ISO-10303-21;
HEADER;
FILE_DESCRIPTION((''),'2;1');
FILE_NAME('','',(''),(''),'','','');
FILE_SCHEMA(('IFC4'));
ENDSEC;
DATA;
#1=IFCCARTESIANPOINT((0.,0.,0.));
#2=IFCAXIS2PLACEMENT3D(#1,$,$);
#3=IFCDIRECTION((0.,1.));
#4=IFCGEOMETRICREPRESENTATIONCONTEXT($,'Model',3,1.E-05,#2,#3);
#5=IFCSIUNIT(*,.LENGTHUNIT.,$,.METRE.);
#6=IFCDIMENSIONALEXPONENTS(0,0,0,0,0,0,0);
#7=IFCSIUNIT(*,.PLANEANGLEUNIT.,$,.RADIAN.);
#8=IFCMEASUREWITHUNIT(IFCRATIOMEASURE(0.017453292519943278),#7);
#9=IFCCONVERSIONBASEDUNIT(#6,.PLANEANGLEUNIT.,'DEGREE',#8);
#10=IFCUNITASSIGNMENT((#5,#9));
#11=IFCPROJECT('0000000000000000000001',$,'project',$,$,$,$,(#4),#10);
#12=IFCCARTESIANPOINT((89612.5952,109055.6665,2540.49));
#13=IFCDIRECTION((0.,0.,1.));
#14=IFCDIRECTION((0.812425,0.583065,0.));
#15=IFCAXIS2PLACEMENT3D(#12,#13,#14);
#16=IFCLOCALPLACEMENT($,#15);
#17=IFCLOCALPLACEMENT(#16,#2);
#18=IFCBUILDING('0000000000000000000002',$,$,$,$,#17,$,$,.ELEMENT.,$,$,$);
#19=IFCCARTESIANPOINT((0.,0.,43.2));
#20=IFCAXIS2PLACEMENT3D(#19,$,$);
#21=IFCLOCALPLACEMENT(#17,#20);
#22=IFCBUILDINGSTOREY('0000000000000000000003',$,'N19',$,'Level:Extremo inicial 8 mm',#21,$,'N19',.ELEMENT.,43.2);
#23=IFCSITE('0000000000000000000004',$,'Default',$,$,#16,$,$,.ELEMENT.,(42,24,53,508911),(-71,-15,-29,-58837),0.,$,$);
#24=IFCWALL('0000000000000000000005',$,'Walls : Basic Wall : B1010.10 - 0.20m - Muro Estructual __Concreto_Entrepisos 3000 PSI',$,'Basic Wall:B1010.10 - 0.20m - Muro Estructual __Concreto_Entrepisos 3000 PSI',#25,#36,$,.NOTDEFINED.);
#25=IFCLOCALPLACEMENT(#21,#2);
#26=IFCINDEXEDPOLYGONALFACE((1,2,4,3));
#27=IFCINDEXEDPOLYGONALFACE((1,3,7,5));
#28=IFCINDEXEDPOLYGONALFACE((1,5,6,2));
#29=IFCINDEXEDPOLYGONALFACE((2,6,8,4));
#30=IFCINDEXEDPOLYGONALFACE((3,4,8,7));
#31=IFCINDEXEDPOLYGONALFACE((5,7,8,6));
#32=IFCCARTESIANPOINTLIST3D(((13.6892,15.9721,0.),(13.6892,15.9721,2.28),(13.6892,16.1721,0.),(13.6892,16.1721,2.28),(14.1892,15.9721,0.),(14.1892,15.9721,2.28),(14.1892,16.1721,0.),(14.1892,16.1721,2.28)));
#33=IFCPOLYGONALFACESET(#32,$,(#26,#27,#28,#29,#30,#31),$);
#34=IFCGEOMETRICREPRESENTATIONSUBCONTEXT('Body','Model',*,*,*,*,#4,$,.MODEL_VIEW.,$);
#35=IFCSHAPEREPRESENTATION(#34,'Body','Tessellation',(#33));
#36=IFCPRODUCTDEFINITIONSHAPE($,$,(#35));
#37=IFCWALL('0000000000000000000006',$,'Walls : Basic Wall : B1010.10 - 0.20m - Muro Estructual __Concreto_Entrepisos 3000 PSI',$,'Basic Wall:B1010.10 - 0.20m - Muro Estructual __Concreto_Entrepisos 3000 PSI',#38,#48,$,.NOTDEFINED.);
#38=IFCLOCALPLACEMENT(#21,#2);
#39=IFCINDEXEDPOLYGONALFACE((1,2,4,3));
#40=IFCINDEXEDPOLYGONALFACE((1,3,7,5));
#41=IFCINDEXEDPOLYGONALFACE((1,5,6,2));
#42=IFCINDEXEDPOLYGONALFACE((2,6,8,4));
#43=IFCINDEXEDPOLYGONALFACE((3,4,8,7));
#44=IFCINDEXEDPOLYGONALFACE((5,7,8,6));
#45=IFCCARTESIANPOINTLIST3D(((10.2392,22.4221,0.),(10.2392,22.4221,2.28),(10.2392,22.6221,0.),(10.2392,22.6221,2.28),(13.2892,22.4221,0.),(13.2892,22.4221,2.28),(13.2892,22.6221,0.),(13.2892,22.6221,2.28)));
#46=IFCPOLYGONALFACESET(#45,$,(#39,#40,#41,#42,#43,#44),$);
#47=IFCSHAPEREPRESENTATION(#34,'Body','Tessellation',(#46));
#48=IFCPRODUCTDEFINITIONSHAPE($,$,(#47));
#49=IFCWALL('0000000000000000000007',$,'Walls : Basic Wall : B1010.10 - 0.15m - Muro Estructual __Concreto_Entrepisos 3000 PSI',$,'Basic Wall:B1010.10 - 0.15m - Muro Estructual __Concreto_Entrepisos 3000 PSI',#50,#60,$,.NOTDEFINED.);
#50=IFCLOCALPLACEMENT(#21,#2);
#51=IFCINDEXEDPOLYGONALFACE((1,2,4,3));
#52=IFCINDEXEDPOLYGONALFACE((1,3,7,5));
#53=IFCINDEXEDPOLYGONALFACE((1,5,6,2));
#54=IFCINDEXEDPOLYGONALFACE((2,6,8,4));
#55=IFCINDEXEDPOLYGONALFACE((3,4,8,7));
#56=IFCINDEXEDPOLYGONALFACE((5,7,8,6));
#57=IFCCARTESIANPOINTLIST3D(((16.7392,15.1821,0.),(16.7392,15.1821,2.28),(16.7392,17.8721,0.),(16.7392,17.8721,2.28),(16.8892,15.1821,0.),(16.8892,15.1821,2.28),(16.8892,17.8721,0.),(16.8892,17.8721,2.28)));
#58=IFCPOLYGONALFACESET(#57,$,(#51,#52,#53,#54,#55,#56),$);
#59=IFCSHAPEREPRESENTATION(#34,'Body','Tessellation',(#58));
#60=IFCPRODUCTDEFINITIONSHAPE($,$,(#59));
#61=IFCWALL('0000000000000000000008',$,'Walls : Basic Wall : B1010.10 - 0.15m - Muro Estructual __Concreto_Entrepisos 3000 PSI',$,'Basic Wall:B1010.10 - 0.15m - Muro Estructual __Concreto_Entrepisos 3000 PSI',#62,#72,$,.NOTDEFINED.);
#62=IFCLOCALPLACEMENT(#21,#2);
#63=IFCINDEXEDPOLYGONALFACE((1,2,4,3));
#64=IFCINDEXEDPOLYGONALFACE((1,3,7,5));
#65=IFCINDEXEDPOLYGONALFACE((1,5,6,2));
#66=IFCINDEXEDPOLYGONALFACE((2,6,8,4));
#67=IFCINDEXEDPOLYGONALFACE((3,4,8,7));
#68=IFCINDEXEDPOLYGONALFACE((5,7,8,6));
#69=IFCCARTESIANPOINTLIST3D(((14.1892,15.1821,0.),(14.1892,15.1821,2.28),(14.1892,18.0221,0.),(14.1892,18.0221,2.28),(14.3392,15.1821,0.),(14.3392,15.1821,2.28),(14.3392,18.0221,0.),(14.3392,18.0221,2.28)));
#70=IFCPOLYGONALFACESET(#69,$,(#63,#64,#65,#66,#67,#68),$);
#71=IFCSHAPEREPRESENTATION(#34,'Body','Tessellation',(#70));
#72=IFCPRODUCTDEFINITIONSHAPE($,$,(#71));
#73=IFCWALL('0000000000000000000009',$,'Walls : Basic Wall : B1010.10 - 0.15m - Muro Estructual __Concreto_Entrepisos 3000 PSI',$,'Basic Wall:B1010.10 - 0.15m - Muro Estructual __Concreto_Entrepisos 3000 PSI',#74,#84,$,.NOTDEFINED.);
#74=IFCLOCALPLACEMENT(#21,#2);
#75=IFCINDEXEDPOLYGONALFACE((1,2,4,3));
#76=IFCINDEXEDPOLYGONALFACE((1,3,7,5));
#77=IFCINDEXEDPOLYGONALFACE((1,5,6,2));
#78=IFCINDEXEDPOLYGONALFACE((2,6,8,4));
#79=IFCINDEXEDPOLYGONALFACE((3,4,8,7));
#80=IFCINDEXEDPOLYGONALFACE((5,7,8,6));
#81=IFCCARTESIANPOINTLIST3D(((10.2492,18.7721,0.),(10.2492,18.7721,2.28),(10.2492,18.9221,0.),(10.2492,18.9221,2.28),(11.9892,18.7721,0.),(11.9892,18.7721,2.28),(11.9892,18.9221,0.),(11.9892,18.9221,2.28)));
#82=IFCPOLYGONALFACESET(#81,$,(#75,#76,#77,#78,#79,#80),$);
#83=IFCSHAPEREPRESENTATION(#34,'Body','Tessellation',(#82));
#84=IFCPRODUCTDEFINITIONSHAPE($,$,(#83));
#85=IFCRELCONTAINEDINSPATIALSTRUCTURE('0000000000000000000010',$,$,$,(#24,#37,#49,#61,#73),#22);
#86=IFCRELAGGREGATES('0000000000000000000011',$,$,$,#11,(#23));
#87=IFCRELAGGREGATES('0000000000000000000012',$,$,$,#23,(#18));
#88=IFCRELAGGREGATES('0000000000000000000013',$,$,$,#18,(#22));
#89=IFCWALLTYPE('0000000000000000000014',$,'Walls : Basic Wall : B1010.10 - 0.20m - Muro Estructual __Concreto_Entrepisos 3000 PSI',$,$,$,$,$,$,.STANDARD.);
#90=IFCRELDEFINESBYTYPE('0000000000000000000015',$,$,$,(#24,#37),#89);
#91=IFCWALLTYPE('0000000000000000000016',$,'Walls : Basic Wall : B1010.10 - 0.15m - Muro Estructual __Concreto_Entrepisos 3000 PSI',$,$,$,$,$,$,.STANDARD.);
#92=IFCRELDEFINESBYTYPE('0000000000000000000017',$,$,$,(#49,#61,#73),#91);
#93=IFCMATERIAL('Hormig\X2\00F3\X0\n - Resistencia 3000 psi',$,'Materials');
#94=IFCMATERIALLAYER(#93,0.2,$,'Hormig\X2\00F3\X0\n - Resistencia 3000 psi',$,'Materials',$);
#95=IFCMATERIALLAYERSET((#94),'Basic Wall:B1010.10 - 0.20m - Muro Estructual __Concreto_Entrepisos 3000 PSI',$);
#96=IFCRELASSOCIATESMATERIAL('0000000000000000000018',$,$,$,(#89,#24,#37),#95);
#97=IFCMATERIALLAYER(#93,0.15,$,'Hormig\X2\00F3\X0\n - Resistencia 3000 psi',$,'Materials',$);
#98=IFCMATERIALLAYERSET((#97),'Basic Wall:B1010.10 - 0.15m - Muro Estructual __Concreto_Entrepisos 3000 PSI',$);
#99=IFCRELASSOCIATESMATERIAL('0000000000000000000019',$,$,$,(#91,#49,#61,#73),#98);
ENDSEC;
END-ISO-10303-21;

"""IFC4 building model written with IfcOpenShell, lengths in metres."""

from ifc_helpers import new_model, entity, si_unit, converted_unit, direction, frame, frame_2d, origin, place, context, subcontext, project, spatial, rectangle, extrude, material, layer, layer_set, layer_usage, type_object, element, save


model = new_model("IFC4")

# Units and contexts
model_context = context("Model", 3, precision=1e-05, world=origin(), true_north=direction((0.0, 1.0)))
body_context = subcontext(model_context, "Body", "Model", "MODEL_VIEW")
ifc_project = project(units=[si_unit("LENGTHUNIT", "METRE"), converted_unit("PLANEANGLEUNIT", "DEGREE", entity("IfcRatioMeasure", 0.017453292519943278), si_unit("PLANEANGLEUNIT", "RADIAN"), dimensions=[0, 0, 0, 0, 0, 0, 0])], contexts=[model_context])

# Site, building, storey
site_placement = place(None, frame((89612.5952, 109055.6665, 2540.49), z_axis=(0.0, 0.0, 1.0), x_axis=(0.812425, 0.583065, 0.0)))
site = spatial("IfcSite", under=ifc_project, at=site_placement, Name="Default", CompositionType="ELEMENT", RefLatitude=(42, 24, 53, 508911), RefLongitude=(-71, -15, -29, -58837), RefElevation=0.0)
building_placement = place(site_placement, origin())
building = spatial("IfcBuilding", under=site, at=building_placement, CompositionType="ELEMENT")
storey_placement = place(building_placement, frame((0.0, 0.0, 43.2)))
storey = spatial("IfcBuildingStorey", under=building, at=storey_placement, Name="N19", ObjectType="Level:Extremo inicial 8 mm", LongName="N19", CompositionType="ELEMENT", Elevation=43.2)

# Walls
ifc_material_1 = material(Name="Hormigón - Resistencia 3000 psi", Category="Materials")
ifc_layer_1 = layer(ifc_material_1, 0.2, Name="Hormigón - Resistencia 3000 psi", Category="Materials")
ifc_layer_set_1 = layer_set([ifc_layer_1], Name="Basic Wall:B1010.10 - 0.20m - Muro Estructual __Concreto_Entrepisos 3000 PSI")
wall_type_1 = type_object("IfcWallType", Name="Walls : Basic Wall : B1010.10 - 0.20m - Muro Estructual __Concreto_Entrepisos 3000 PSI", PredefinedType="STANDARD", material=ifc_layer_set_1)
ifc_layer_usage_1 = layer_usage(ifc_layer_set_1, "AXIS2", "NEGATIVE", 0.1)
wall_1_placement = place(storey_placement, frame((13.6892, 16.0721, 0.0)))
element("IfcWall", 1, at=wall_1_placement, inside=storey, type_object=wall_type_1, material=ifc_layer_usage_1, Name="Walls : Basic Wall : B1010.10 - 0.20m - Muro Estructual __Concreto_Entrepisos 3000 PSI", ObjectType="Basic Wall:B1010.10 - 0.20m - Muro Estructual __Concreto_Entrepisos 3000 PSI", PredefinedType="NOTDEFINED", context=body_context, shape_type="SweptSolid", body=[
    extrude(rectangle(XDim=0.5, YDim=0.2, at=frame_2d((0.25, 0.0), x_axis=(-1.0, 0.0))), origin(), (0.0, 0.0, 1.0), 2.28),
])
ifc_layer_usage_2 = layer_usage(ifc_layer_set_1, "AXIS2", "POSITIVE", -0.1)
wall_2_placement = place(storey_placement, frame((10.2392, 22.5221, 0.0)))
element("IfcWall", 2, at=wall_2_placement, inside=storey, type_object=wall_type_1, material=ifc_layer_usage_2, Name="Walls : Basic Wall : B1010.10 - 0.20m - Muro Estructual __Concreto_Entrepisos 3000 PSI", ObjectType="Basic Wall:B1010.10 - 0.20m - Muro Estructual __Concreto_Entrepisos 3000 PSI", PredefinedType="NOTDEFINED", context=body_context, shape_type="SweptSolid", body=[
    extrude(rectangle(XDim=3.05, YDim=0.2, at=frame_2d((1.525, 0.0), x_axis=(-1.0, 0.0))), origin(), (0.0, 0.0, 1.0), 2.28),
])
ifc_layer_2 = layer(ifc_material_1, 0.15, Name="Hormigón - Resistencia 3000 psi", Category="Materials")
ifc_layer_set_2 = layer_set([ifc_layer_2], Name="Basic Wall:B1010.10 - 0.15m - Muro Estructual __Concreto_Entrepisos 3000 PSI")
ifc_layer_usage_3 = layer_usage(ifc_layer_set_2, "AXIS2", "NEGATIVE", 0.075)
wall_type_2 = type_object("IfcWallType", Name="Walls : Basic Wall : B1010.10 - 0.15m - Muro Estructual __Concreto_Entrepisos 3000 PSI", PredefinedType="STANDARD", material=ifc_layer_set_2)
wall_3_placement = place(storey_placement, frame((16.8142, 15.1821, 0.0), z_axis=(0.0, 0.0, 1.0), x_axis=(0.0, 1.0, 0.0)))
element("IfcWall", 3, at=wall_3_placement, inside=storey, type_object=wall_type_2, material=ifc_layer_usage_3, Name="Walls : Basic Wall : B1010.10 - 0.15m - Muro Estructual __Concreto_Entrepisos 3000 PSI", ObjectType="Basic Wall:B1010.10 - 0.15m - Muro Estructual __Concreto_Entrepisos 3000 PSI", PredefinedType="NOTDEFINED", context=body_context, shape_type="SweptSolid", body=[
    extrude(rectangle(XDim=2.69, YDim=0.15, at=frame_2d((1.345, 0.0), x_axis=(-1.0, 0.0))), origin(), (0.0, 0.0, 1.0), 2.28),
])
ifc_layer_usage_4 = layer_usage(ifc_layer_set_2, "AXIS2", "NEGATIVE", 0.075)
wall_4_placement = place(storey_placement, frame((14.2642, 15.1821, 0.0), z_axis=(0.0, 0.0, 1.0), x_axis=(0.0, 1.0, 0.0)))
element("IfcWall", 4, at=wall_4_placement, inside=storey, type_object=wall_type_2, material=ifc_layer_usage_4, Name="Walls : Basic Wall : B1010.10 - 0.15m - Muro Estructual __Concreto_Entrepisos 3000 PSI", ObjectType="Basic Wall:B1010.10 - 0.15m - Muro Estructual __Concreto_Entrepisos 3000 PSI", PredefinedType="NOTDEFINED", context=body_context, shape_type="SweptSolid", body=[
    extrude(rectangle(XDim=2.84, YDim=0.15, at=frame_2d((1.42, 0.0), x_axis=(-1.0, 0.0))), origin(), (0.0, 0.0, 1.0), 2.28),
])
ifc_layer_usage_5 = layer_usage(ifc_layer_set_2, "AXIS2", "NEGATIVE", 0.075)
wall_5_placement = place(storey_placement, frame((11.9892, 18.8471, 0.0), z_axis=(0.0, 0.0, 1.0), x_axis=(-1.0, 0.0, 0.0)))
element("IfcWall", 5, at=wall_5_placement, inside=storey, type_object=wall_type_2, material=ifc_layer_usage_5, Name="Walls : Basic Wall : B1010.10 - 0.15m - Muro Estructual __Concreto_Entrepisos 3000 PSI", ObjectType="Basic Wall:B1010.10 - 0.15m - Muro Estructual __Concreto_Entrepisos 3000 PSI", PredefinedType="NOTDEFINED", context=body_context, shape_type="SweptSolid", body=[
    extrude(rectangle(XDim=1.74, YDim=0.15, at=frame_2d((0.87, 0.0), x_axis=(-1.0, 0.0))), origin(), (0.0, 0.0, 1.0), 2.28),
])

save(model, "model.ifc")
